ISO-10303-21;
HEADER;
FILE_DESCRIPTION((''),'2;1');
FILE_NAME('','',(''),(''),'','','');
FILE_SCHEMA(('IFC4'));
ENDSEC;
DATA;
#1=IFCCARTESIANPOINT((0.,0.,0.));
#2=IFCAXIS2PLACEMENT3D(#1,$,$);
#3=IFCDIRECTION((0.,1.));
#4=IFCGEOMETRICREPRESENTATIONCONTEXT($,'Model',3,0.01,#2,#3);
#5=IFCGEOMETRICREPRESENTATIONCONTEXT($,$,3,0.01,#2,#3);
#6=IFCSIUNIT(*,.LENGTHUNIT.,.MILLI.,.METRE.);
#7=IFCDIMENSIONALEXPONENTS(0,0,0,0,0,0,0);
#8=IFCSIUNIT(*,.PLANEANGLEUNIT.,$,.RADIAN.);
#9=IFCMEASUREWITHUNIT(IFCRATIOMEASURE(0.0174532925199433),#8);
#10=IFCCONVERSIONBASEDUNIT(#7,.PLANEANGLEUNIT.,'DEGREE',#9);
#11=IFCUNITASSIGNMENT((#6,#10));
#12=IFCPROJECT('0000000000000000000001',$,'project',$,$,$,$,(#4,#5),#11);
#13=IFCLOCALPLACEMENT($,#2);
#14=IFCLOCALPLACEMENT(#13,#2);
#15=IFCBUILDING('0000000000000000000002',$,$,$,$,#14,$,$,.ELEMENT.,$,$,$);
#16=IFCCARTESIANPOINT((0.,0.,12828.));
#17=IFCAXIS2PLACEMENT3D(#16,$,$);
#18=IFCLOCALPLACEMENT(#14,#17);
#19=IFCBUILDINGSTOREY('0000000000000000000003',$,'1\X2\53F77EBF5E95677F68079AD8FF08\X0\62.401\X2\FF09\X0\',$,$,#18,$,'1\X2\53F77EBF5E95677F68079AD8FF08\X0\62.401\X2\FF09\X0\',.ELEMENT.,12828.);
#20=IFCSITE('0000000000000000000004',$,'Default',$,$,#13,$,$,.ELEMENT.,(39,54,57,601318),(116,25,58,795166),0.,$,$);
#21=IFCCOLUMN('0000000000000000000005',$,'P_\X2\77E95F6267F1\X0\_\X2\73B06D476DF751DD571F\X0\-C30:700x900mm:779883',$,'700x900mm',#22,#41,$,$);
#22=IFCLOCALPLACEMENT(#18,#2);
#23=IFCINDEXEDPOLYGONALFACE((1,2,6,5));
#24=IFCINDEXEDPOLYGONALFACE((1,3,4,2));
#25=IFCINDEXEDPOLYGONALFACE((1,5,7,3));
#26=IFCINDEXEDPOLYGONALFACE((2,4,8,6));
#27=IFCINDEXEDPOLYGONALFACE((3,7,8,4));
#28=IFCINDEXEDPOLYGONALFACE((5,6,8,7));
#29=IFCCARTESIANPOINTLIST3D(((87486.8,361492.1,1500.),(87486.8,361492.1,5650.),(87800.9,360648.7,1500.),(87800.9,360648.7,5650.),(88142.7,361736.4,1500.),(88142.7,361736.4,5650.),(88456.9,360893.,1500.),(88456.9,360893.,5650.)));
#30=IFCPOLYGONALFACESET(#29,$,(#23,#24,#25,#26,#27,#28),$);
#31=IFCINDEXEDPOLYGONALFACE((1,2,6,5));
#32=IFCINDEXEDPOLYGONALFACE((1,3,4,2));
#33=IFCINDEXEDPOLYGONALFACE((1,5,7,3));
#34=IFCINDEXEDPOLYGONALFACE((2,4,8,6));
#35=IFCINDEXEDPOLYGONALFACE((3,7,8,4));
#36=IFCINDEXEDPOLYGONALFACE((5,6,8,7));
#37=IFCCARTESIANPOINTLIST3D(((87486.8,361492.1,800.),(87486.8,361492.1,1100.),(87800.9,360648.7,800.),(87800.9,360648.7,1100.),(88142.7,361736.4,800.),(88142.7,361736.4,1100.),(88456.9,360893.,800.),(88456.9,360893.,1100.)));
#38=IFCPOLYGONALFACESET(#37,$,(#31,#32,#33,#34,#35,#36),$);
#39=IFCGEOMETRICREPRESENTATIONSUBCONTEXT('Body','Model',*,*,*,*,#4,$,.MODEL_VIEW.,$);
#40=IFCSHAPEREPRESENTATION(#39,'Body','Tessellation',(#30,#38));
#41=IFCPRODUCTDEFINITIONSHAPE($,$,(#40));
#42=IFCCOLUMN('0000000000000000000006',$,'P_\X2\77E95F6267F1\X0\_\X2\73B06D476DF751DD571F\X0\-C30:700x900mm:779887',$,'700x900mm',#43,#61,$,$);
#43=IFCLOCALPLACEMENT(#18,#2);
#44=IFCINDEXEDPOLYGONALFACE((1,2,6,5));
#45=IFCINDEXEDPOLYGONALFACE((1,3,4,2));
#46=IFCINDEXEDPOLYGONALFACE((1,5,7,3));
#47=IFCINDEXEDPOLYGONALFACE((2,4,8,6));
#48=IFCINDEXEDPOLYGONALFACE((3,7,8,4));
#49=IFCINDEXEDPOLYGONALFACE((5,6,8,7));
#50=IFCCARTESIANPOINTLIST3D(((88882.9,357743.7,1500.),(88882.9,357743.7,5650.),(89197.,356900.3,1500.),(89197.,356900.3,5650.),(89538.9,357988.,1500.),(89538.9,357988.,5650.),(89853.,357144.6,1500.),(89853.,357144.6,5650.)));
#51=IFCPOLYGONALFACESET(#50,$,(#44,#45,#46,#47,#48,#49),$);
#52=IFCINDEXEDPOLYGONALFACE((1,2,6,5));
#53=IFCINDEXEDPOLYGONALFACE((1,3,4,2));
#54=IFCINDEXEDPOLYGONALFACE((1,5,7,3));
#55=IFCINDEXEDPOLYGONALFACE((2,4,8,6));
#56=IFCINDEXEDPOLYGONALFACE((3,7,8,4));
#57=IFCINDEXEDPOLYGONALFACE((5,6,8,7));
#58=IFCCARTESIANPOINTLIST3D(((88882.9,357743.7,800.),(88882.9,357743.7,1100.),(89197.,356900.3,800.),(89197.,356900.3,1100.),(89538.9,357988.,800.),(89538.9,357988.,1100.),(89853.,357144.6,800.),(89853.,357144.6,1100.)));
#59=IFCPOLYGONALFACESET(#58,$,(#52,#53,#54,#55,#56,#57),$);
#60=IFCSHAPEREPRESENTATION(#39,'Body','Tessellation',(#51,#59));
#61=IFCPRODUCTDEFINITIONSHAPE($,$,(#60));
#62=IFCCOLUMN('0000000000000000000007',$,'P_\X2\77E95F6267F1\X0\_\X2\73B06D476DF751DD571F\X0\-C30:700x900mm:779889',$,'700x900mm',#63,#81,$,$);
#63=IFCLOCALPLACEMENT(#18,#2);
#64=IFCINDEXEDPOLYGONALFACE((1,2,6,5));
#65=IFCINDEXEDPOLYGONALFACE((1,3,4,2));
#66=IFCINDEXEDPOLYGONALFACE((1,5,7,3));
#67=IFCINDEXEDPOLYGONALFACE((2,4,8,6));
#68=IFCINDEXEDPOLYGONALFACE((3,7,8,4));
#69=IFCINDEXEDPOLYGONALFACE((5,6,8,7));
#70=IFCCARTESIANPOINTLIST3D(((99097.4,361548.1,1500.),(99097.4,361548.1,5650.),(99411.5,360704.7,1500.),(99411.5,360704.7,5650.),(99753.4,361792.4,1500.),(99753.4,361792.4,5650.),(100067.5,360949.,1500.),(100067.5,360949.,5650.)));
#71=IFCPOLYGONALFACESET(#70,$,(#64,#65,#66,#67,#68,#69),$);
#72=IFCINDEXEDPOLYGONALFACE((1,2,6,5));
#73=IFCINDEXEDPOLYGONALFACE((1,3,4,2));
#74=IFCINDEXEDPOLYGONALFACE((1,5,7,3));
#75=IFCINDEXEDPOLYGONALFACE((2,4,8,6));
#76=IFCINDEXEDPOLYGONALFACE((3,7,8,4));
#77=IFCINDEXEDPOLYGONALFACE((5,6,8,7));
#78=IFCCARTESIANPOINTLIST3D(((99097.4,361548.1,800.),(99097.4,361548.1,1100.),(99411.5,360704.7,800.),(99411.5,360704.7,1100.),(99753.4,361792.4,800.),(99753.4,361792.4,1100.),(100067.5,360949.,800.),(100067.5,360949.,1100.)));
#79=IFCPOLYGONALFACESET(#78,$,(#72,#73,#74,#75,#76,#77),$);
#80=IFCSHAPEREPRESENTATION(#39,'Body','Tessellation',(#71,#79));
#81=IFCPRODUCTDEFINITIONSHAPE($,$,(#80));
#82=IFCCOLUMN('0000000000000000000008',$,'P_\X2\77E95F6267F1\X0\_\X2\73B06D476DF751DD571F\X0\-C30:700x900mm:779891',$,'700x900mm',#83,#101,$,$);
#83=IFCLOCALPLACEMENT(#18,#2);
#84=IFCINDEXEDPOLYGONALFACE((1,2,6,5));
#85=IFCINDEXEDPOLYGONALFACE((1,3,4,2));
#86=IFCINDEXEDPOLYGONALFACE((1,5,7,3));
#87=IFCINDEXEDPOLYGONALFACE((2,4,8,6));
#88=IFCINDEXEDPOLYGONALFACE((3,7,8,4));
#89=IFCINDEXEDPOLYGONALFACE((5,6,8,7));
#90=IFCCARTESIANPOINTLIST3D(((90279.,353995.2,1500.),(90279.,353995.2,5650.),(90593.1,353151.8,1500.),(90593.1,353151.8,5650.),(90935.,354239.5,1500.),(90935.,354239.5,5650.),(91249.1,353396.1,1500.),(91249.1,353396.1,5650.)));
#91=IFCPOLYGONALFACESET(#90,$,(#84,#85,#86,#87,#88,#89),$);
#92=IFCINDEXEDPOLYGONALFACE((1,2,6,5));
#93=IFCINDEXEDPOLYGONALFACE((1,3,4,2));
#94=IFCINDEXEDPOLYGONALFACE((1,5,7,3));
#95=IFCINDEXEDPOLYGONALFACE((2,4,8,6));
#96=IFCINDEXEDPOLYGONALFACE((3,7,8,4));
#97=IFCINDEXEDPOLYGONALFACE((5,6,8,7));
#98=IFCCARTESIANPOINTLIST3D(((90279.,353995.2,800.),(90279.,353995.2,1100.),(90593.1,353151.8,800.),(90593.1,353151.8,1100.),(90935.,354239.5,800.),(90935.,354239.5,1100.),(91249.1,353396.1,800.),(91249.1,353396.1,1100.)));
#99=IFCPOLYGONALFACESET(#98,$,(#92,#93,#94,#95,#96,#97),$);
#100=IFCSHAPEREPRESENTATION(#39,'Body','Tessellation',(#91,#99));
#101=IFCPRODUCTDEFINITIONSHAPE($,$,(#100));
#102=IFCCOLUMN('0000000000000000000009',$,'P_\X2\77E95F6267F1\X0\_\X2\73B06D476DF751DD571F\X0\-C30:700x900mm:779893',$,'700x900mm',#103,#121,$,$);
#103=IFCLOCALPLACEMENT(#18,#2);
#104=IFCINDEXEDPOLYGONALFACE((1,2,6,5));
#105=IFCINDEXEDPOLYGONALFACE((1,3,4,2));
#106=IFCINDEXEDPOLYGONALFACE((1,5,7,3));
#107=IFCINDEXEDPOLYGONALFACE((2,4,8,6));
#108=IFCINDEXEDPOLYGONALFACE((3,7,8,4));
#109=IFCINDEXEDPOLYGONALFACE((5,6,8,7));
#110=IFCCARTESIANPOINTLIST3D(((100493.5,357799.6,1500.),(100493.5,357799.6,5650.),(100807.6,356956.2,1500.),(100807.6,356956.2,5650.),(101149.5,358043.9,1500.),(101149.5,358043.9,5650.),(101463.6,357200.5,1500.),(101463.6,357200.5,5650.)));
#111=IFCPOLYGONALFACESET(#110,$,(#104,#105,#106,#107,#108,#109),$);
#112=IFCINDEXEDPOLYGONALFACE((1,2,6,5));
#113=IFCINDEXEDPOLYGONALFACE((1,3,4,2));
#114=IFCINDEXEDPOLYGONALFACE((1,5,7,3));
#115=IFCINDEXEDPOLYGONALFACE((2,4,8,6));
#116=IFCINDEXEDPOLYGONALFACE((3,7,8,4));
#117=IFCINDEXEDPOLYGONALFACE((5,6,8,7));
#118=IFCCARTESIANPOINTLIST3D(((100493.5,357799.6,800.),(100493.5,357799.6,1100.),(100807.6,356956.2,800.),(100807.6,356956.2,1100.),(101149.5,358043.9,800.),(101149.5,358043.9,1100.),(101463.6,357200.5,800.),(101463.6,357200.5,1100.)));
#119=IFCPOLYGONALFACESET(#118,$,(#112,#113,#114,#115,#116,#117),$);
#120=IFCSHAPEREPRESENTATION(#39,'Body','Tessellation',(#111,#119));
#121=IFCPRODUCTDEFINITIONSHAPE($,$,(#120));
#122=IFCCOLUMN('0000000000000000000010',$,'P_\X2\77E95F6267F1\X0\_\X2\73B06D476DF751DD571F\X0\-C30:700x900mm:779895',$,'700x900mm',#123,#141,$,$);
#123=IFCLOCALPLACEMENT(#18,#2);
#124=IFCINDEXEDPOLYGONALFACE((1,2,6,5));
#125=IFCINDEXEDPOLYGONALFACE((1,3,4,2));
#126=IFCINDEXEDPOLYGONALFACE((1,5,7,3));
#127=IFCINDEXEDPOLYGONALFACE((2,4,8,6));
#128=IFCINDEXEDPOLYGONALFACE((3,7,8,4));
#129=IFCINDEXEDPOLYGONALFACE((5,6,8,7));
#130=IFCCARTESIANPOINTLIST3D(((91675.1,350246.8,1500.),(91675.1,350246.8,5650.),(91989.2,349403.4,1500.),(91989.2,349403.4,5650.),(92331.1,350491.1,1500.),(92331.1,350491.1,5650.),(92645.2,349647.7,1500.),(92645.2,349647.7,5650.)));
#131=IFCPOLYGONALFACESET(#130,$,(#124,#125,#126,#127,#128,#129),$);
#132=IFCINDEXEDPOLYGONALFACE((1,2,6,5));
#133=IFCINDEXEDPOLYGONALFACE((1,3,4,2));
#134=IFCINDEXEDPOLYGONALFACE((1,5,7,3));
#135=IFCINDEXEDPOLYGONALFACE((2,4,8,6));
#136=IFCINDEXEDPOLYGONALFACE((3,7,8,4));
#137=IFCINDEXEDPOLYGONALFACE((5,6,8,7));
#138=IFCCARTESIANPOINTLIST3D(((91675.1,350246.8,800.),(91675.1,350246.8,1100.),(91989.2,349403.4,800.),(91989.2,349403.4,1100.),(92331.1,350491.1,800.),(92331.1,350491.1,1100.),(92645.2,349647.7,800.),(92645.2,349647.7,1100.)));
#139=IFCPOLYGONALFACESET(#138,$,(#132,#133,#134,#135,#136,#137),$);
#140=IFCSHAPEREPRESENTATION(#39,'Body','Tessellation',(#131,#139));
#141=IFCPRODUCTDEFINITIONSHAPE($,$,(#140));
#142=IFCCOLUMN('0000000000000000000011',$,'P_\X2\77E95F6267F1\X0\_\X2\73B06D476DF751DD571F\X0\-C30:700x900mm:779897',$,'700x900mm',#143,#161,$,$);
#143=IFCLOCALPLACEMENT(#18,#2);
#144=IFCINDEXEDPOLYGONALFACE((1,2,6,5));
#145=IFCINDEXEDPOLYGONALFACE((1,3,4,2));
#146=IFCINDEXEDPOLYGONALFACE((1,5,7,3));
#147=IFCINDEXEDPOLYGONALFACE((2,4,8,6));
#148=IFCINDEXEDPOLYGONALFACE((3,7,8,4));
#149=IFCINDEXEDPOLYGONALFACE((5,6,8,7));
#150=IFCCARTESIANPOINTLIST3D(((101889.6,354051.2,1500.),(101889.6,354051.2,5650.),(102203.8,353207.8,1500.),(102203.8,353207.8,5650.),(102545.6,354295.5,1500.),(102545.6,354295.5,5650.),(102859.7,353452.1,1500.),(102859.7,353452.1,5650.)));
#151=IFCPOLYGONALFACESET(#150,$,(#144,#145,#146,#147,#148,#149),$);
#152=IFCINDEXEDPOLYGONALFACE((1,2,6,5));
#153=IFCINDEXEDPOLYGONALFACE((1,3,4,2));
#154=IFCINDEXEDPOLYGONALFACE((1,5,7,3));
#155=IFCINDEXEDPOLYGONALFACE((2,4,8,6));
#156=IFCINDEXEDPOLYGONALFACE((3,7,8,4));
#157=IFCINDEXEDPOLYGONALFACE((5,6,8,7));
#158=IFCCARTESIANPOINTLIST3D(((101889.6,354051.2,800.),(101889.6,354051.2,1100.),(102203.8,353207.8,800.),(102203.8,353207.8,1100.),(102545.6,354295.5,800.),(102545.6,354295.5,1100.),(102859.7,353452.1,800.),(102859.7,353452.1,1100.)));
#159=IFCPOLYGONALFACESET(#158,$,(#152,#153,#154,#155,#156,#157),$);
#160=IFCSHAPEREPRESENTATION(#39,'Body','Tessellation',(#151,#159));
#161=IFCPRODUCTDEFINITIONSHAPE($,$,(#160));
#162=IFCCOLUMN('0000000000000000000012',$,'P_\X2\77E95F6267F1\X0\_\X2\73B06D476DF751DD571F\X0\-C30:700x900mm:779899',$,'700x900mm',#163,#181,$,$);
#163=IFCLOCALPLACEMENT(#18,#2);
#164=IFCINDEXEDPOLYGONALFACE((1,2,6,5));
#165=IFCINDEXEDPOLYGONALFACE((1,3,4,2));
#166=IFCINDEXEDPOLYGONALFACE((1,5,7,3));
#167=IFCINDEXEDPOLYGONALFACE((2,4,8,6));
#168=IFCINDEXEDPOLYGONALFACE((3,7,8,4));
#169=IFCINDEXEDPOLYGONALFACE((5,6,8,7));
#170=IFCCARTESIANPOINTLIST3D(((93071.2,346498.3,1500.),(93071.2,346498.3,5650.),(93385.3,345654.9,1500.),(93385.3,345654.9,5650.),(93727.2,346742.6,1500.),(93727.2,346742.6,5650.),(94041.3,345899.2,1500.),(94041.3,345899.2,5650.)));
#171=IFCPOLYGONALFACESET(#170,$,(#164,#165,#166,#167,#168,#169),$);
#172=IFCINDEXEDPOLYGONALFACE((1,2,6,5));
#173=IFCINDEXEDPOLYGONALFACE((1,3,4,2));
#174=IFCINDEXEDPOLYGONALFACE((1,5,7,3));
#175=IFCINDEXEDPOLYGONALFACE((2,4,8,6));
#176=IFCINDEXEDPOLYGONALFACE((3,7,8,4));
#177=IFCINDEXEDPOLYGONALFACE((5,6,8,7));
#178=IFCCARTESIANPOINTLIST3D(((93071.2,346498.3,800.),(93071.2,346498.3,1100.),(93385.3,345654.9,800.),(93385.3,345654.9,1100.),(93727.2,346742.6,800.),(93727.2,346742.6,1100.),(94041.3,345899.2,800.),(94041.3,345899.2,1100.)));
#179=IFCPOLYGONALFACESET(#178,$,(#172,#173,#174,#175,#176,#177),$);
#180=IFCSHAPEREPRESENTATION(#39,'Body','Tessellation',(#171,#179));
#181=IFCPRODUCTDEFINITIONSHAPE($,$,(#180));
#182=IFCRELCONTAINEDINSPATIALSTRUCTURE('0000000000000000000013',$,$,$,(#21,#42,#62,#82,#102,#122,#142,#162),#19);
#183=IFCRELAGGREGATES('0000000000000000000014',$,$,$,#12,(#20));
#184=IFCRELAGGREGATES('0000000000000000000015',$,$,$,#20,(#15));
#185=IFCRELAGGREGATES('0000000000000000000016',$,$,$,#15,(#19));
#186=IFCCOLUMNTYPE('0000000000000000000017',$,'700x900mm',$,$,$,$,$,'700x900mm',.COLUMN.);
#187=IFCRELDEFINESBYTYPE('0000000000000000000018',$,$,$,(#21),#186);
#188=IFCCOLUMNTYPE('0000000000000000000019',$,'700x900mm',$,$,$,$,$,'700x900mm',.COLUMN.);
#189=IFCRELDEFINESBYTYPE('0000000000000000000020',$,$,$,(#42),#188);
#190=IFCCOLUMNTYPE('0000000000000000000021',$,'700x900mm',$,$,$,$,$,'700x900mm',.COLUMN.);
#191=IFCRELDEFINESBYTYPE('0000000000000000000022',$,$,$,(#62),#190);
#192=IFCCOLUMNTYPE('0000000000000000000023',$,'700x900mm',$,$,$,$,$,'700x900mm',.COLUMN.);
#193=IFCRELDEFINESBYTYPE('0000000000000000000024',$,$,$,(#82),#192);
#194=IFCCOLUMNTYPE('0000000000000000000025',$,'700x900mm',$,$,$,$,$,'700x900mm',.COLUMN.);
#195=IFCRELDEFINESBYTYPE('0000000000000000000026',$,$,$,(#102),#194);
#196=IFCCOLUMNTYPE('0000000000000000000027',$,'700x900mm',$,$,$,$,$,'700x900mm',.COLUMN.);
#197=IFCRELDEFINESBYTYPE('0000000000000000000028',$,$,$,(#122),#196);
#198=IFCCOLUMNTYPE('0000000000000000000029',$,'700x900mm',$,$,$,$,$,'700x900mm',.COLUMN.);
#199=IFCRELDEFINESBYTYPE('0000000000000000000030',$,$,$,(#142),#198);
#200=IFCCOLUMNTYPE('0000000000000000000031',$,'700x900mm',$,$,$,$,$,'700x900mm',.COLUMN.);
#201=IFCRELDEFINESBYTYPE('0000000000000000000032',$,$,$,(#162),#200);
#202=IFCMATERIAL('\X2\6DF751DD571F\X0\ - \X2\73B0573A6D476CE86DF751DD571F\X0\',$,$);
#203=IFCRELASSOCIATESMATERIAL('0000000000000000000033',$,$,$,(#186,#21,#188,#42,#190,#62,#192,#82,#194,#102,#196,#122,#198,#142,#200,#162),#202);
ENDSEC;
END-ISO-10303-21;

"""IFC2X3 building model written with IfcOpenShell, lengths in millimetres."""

from ifc_helpers import new_model, entity, si_unit, converted_unit, direction, frame, frame_2d, origin, place, context, subcontext, project, spatial, rectangle, extrude, source, transform, mapped, material, type_object, type_shapes, element, save


model = new_model("IFC2X3")

# Units and contexts
model_context = context("Model", 3, precision=0.01, world=origin(), true_north=direction((0.0, 1.0)))
context_of_model = context(None, 3, precision=0.01, world=origin(), true_north=direction((0.0, 1.0)))
body_context = subcontext(model_context, "Body", "Model", "MODEL_VIEW")
ifc_project = project(units=[si_unit("LENGTHUNIT", "METRE", prefix="MILLI"), converted_unit("PLANEANGLEUNIT", "DEGREE", entity("IfcRatioMeasure", 0.0174532925199433), si_unit("PLANEANGLEUNIT", "RADIAN"), dimensions=[0, 0, 0, 0, 0, 0, 0])], contexts=[model_context, context_of_model])

# Site, building, storey
site_placement = place(None, origin())
site = spatial("IfcSite", under=ifc_project, at=site_placement, Name="Default", CompositionType="ELEMENT", RefLatitude=(39, 54, 57, 601318), RefLongitude=(116, 25, 58, 795166), RefElevation=0.0)
building_placement = place(site_placement, origin())
building = spatial("IfcBuilding", under=site, at=building_placement, CompositionType="ELEMENT")
storey_placement = place(building_placement, frame((0.0, 0.0, 12828.0)))
storey = spatial("IfcBuildingStorey", under=building, at=storey_placement, Name="1号线底板标高（62.401）", LongName="1号线底板标高（62.401）", CompositionType="ELEMENT", Elevation=12828.0)

# Columns
ifc_material_1 = material(Name="混凝土 - 现场浇注混凝土")
column_type_1 = type_object("IfcColumnType", Name="700x900mm", ElementType="700x900mm", PredefinedType="COLUMN", material=ifc_material_1)
shared_shape_1 = source(origin(), body_context, "Body", "SweptSolid", [
    extrude(rectangle(XDim=700.0, YDim=900.0, at=frame_2d((0.0, 0.0), x_axis=(1.0, 0.0))), frame((485.1, 543.9, 700.0), z_axis=(0.0, 0.0, 1.0), x_axis=(-0.937112, -0.349028, 0.0)), (0.0, 0.0, 1.0), 4150.0),
    extrude(rectangle(XDim=900.0, YDim=700.0, at=frame_2d((0.0, 0.0), x_axis=(1.0, 0.0))), frame((485.1, 543.9, 0.0), z_axis=(0.0, 0.0, 1.0), x_axis=(-0.349028, 0.937112, 0.0)), (0.0, 0.0, 1.0), 300.0),
])
type_shapes(column_type_1, [shared_shape_1])
column_1_placement = place(storey_placement, frame((87486.8, 360648.7, 800.0)))
element("IfcColumn", 1, at=column_1_placement, inside=storey, type_object=column_type_1, material=ifc_material_1, Name="P_矩形柱_现浇混凝土-C30:700x900mm:779883", ObjectType="700x900mm", context=body_context, shape_type="MappedRepresentation", body=[
    mapped(shared_shape_1, transform((0.0, 0.0, 0.0), scale=1.0)),
])
column_type_2 = type_object("IfcColumnType", Name="700x900mm", ElementType="700x900mm", PredefinedType="COLUMN", material=ifc_material_1)
shared_shape_2 = source(origin(), body_context, "Body", "SweptSolid", [
    extrude(rectangle(XDim=700.0, YDim=900.0, at=frame_2d((0.0, 0.0), x_axis=(1.0, 0.0))), frame((485.1, 543.9, 700.0), z_axis=(0.0, 0.0, 1.0), x_axis=(-0.937112, -0.349028, 0.0)), (0.0, 0.0, 1.0), 4150.0),
    extrude(rectangle(XDim=700.0, YDim=900.0, at=frame_2d((0.0, 0.0), x_axis=(1.0, 0.0))), frame((485.1, 543.9, 0.0), z_axis=(0.0, 0.0, 1.0), x_axis=(-0.937112, -0.349028, 0.0)), (0.0, 0.0, 1.0), 300.0),
])
type_shapes(column_type_2, [shared_shape_2])
column_2_placement = place(storey_placement, frame((88882.9, 356900.3, 800.0)))
element("IfcColumn", 2, at=column_2_placement, inside=storey, type_object=column_type_2, material=ifc_material_1, Name="P_矩形柱_现浇混凝土-C30:700x900mm:779887", ObjectType="700x900mm", context=body_context, shape_type="MappedRepresentation", body=[
    mapped(shared_shape_2, transform((0.0, 0.0, 0.0), scale=1.0)),
])
column_type_3 = type_object("IfcColumnType", Name="700x900mm", ElementType="700x900mm", PredefinedType="COLUMN", material=ifc_material_1)
shared_shape_3 = source(origin(), body_context, "Body", "SweptSolid", [
    extrude(rectangle(XDim=700.0, YDim=900.0, at=frame_2d((0.0, 0.0), x_axis=(1.0, 0.0))), frame((485.1, 543.9, 700.0), z_axis=(0.0, 0.0, 1.0), x_axis=(-0.937112, -0.349028, 0.0)), (0.0, 0.0, 1.0), 4150.0),
    extrude(rectangle(XDim=700.0, YDim=900.0, at=frame_2d((0.0, 0.0), x_axis=(1.0, 0.0))), frame((485.1, 543.9, 0.0), z_axis=(0.0, 0.0, 1.0), x_axis=(-0.937112, -0.349028, 0.0)), (0.0, 0.0, 1.0), 300.0),
])
type_shapes(column_type_3, [shared_shape_3])
column_3_placement = place(storey_placement, frame((99097.4, 360704.7, 800.0)))
element("IfcColumn", 3, at=column_3_placement, inside=storey, type_object=column_type_3, material=ifc_material_1, Name="P_矩形柱_现浇混凝土-C30:700x900mm:779889", ObjectType="700x900mm", context=body_context, shape_type="MappedRepresentation", body=[
    mapped(shared_shape_3, transform((0.0, 0.0, 0.0), scale=1.0)),
])
column_type_4 = type_object("IfcColumnType", Name="700x900mm", ElementType="700x900mm", PredefinedType="COLUMN", material=ifc_material_1)
shared_shape_4 = source(origin(), body_context, "Body", "SweptSolid", [
    extrude(rectangle(XDim=700.0, YDim=900.0, at=frame_2d((0.0, 0.0), x_axis=(1.0, 0.0))), frame((485.1, 543.9, 700.0), z_axis=(0.0, 0.0, 1.0), x_axis=(-0.937112, -0.349028, 0.0)), (0.0, 0.0, 1.0), 4150.0),
    extrude(rectangle(XDim=700.0, YDim=900.0, at=frame_2d((0.0, 0.0), x_axis=(1.0, 0.0))), frame((485.1, 543.9, 0.0), z_axis=(0.0, 0.0, 1.0), x_axis=(-0.937112, -0.349028, 0.0)), (0.0, 0.0, 1.0), 300.0),
])
type_shapes(column_type_4, [shared_shape_4])
column_4_placement = place(storey_placement, frame((90279.0, 353151.8, 800.0)))
element("IfcColumn", 4, at=column_4_placement, inside=storey, type_object=column_type_4, material=ifc_material_1, Name="P_矩形柱_现浇混凝土-C30:700x900mm:779891", ObjectType="700x900mm", context=body_context, shape_type="MappedRepresentation", body=[
    mapped(shared_shape_4, transform((0.0, 0.0, 0.0), scale=1.0)),
])
column_type_5 = type_object("IfcColumnType", Name="700x900mm", ElementType="700x900mm", PredefinedType="COLUMN", material=ifc_material_1)
shared_shape_5 = source(origin(), body_context, "Body", "SweptSolid", [
    extrude(rectangle(XDim=700.0, YDim=900.0, at=frame_2d((0.0, 0.0), x_axis=(1.0, 0.0))), frame((485.1, 543.9, 700.0), z_axis=(0.0, 0.0, 1.0), x_axis=(-0.937112, -0.349028, 0.0)), (0.0, 0.0, 1.0), 4150.0),
    extrude(rectangle(XDim=700.0, YDim=900.0, at=frame_2d((0.0, 0.0), x_axis=(1.0, 0.0))), frame((485.1, 543.9, 0.0), z_axis=(0.0, 0.0, 1.0), x_axis=(-0.937112, -0.349028, 0.0)), (0.0, 0.0, 1.0), 300.0),
])
type_shapes(column_type_5, [shared_shape_5])
column_5_placement = place(storey_placement, frame((100493.5, 356956.2, 800.0)))
element("IfcColumn", 5, at=column_5_placement, inside=storey, type_object=column_type_5, material=ifc_material_1, Name="P_矩形柱_现浇混凝土-C30:700x900mm:779893", ObjectType="700x900mm", context=body_context, shape_type="MappedRepresentation", body=[
    mapped(shared_shape_5, transform((0.0, 0.0, 0.0), scale=1.0)),
])
column_type_6 = type_object("IfcColumnType", Name="700x900mm", ElementType="700x900mm", PredefinedType="COLUMN", material=ifc_material_1)
shared_shape_6 = source(origin(), body_context, "Body", "SweptSolid", [
    extrude(rectangle(XDim=700.0, YDim=900.0, at=frame_2d((0.0, 0.0), x_axis=(1.0, 0.0))), frame((485.1, 543.9, 700.0), z_axis=(0.0, 0.0, 1.0), x_axis=(-0.937112, -0.349028, 0.0)), (0.0, 0.0, 1.0), 4150.0),
    extrude(rectangle(XDim=700.0, YDim=900.0, at=frame_2d((0.0, 0.0), x_axis=(1.0, 0.0))), frame((485.1, 543.9, 0.0), z_axis=(0.0, 0.0, 1.0), x_axis=(-0.937112, -0.349028, 0.0)), (0.0, 0.0, 1.0), 300.0),
])
type_shapes(column_type_6, [shared_shape_6])
column_6_placement = place(storey_placement, frame((91675.1, 349403.4, 800.0)))
element("IfcColumn", 6, at=column_6_placement, inside=storey, type_object=column_type_6, material=ifc_material_1, Name="P_矩形柱_现浇混凝土-C30:700x900mm:779895", ObjectType="700x900mm", context=body_context, shape_type="MappedRepresentation", body=[
    mapped(shared_shape_6, transform((0.0, 0.0, 0.0), scale=1.0)),
])
column_type_7 = type_object("IfcColumnType", Name="700x900mm", ElementType="700x900mm", PredefinedType="COLUMN", material=ifc_material_1)
shared_shape_7 = source(origin(), body_context, "Body", "SweptSolid", [
    extrude(rectangle(XDim=700.0, YDim=900.0, at=frame_2d((0.0, 0.0), x_axis=(1.0, 0.0))), frame((485.1, 543.9, 700.0), z_axis=(0.0, 0.0, 1.0), x_axis=(-0.937112, -0.349028, 0.0)), (0.0, 0.0, 1.0), 4150.0),
    extrude(rectangle(XDim=700.0, YDim=900.0, at=frame_2d((0.0, 0.0), x_axis=(1.0, 0.0))), frame((485.1, 543.9, 0.0), z_axis=(0.0, 0.0, 1.0), x_axis=(-0.937112, -0.349028, 0.0)), (0.0, 0.0, 1.0), 300.0),
])
type_shapes(column_type_7, [shared_shape_7])
column_7_placement = place(storey_placement, frame((101889.6, 353207.8, 800.0)))
element("IfcColumn", 7, at=column_7_placement, inside=storey, type_object=column_type_7, material=ifc_material_1, Name="P_矩形柱_现浇混凝土-C30:700x900mm:779897", ObjectType="700x900mm", context=body_context, shape_type="MappedRepresentation", body=[
    mapped(shared_shape_7, transform((0.0, 0.0, 0.0), scale=1.0)),
])
column_type_8 = type_object("IfcColumnType", Name="700x900mm", ElementType="700x900mm", PredefinedType="COLUMN", material=ifc_material_1)
shared_shape_8 = source(origin(), body_context, "Body", "SweptSolid", [
    extrude(rectangle(XDim=700.0, YDim=900.0, at=frame_2d((0.0, 0.0), x_axis=(1.0, 0.0))), frame((485.1, 543.9, 700.0), z_axis=(0.0, 0.0, 1.0), x_axis=(-0.937112, -0.349028, 0.0)), (0.0, 0.0, 1.0), 4150.0),
    extrude(rectangle(XDim=700.0, YDim=900.0, at=frame_2d((0.0, 0.0), x_axis=(1.0, 0.0))), frame((485.1, 543.9, 0.0), z_axis=(0.0, 0.0, 1.0), x_axis=(-0.937112, -0.349028, 0.0)), (0.0, 0.0, 1.0), 300.0),
])
type_shapes(column_type_8, [shared_shape_8])
column_8_placement = place(storey_placement, frame((93071.2, 345654.9, 800.0)))
element("IfcColumn", 8, at=column_8_placement, inside=storey, type_object=column_type_8, material=ifc_material_1, Name="P_矩形柱_现浇混凝土-C30:700x900mm:779899", ObjectType="700x900mm", context=body_context, shape_type="MappedRepresentation", body=[
    mapped(shared_shape_8, transform((0.0, 0.0, 0.0), scale=1.0)),
])

save(model, "model.ifc")
